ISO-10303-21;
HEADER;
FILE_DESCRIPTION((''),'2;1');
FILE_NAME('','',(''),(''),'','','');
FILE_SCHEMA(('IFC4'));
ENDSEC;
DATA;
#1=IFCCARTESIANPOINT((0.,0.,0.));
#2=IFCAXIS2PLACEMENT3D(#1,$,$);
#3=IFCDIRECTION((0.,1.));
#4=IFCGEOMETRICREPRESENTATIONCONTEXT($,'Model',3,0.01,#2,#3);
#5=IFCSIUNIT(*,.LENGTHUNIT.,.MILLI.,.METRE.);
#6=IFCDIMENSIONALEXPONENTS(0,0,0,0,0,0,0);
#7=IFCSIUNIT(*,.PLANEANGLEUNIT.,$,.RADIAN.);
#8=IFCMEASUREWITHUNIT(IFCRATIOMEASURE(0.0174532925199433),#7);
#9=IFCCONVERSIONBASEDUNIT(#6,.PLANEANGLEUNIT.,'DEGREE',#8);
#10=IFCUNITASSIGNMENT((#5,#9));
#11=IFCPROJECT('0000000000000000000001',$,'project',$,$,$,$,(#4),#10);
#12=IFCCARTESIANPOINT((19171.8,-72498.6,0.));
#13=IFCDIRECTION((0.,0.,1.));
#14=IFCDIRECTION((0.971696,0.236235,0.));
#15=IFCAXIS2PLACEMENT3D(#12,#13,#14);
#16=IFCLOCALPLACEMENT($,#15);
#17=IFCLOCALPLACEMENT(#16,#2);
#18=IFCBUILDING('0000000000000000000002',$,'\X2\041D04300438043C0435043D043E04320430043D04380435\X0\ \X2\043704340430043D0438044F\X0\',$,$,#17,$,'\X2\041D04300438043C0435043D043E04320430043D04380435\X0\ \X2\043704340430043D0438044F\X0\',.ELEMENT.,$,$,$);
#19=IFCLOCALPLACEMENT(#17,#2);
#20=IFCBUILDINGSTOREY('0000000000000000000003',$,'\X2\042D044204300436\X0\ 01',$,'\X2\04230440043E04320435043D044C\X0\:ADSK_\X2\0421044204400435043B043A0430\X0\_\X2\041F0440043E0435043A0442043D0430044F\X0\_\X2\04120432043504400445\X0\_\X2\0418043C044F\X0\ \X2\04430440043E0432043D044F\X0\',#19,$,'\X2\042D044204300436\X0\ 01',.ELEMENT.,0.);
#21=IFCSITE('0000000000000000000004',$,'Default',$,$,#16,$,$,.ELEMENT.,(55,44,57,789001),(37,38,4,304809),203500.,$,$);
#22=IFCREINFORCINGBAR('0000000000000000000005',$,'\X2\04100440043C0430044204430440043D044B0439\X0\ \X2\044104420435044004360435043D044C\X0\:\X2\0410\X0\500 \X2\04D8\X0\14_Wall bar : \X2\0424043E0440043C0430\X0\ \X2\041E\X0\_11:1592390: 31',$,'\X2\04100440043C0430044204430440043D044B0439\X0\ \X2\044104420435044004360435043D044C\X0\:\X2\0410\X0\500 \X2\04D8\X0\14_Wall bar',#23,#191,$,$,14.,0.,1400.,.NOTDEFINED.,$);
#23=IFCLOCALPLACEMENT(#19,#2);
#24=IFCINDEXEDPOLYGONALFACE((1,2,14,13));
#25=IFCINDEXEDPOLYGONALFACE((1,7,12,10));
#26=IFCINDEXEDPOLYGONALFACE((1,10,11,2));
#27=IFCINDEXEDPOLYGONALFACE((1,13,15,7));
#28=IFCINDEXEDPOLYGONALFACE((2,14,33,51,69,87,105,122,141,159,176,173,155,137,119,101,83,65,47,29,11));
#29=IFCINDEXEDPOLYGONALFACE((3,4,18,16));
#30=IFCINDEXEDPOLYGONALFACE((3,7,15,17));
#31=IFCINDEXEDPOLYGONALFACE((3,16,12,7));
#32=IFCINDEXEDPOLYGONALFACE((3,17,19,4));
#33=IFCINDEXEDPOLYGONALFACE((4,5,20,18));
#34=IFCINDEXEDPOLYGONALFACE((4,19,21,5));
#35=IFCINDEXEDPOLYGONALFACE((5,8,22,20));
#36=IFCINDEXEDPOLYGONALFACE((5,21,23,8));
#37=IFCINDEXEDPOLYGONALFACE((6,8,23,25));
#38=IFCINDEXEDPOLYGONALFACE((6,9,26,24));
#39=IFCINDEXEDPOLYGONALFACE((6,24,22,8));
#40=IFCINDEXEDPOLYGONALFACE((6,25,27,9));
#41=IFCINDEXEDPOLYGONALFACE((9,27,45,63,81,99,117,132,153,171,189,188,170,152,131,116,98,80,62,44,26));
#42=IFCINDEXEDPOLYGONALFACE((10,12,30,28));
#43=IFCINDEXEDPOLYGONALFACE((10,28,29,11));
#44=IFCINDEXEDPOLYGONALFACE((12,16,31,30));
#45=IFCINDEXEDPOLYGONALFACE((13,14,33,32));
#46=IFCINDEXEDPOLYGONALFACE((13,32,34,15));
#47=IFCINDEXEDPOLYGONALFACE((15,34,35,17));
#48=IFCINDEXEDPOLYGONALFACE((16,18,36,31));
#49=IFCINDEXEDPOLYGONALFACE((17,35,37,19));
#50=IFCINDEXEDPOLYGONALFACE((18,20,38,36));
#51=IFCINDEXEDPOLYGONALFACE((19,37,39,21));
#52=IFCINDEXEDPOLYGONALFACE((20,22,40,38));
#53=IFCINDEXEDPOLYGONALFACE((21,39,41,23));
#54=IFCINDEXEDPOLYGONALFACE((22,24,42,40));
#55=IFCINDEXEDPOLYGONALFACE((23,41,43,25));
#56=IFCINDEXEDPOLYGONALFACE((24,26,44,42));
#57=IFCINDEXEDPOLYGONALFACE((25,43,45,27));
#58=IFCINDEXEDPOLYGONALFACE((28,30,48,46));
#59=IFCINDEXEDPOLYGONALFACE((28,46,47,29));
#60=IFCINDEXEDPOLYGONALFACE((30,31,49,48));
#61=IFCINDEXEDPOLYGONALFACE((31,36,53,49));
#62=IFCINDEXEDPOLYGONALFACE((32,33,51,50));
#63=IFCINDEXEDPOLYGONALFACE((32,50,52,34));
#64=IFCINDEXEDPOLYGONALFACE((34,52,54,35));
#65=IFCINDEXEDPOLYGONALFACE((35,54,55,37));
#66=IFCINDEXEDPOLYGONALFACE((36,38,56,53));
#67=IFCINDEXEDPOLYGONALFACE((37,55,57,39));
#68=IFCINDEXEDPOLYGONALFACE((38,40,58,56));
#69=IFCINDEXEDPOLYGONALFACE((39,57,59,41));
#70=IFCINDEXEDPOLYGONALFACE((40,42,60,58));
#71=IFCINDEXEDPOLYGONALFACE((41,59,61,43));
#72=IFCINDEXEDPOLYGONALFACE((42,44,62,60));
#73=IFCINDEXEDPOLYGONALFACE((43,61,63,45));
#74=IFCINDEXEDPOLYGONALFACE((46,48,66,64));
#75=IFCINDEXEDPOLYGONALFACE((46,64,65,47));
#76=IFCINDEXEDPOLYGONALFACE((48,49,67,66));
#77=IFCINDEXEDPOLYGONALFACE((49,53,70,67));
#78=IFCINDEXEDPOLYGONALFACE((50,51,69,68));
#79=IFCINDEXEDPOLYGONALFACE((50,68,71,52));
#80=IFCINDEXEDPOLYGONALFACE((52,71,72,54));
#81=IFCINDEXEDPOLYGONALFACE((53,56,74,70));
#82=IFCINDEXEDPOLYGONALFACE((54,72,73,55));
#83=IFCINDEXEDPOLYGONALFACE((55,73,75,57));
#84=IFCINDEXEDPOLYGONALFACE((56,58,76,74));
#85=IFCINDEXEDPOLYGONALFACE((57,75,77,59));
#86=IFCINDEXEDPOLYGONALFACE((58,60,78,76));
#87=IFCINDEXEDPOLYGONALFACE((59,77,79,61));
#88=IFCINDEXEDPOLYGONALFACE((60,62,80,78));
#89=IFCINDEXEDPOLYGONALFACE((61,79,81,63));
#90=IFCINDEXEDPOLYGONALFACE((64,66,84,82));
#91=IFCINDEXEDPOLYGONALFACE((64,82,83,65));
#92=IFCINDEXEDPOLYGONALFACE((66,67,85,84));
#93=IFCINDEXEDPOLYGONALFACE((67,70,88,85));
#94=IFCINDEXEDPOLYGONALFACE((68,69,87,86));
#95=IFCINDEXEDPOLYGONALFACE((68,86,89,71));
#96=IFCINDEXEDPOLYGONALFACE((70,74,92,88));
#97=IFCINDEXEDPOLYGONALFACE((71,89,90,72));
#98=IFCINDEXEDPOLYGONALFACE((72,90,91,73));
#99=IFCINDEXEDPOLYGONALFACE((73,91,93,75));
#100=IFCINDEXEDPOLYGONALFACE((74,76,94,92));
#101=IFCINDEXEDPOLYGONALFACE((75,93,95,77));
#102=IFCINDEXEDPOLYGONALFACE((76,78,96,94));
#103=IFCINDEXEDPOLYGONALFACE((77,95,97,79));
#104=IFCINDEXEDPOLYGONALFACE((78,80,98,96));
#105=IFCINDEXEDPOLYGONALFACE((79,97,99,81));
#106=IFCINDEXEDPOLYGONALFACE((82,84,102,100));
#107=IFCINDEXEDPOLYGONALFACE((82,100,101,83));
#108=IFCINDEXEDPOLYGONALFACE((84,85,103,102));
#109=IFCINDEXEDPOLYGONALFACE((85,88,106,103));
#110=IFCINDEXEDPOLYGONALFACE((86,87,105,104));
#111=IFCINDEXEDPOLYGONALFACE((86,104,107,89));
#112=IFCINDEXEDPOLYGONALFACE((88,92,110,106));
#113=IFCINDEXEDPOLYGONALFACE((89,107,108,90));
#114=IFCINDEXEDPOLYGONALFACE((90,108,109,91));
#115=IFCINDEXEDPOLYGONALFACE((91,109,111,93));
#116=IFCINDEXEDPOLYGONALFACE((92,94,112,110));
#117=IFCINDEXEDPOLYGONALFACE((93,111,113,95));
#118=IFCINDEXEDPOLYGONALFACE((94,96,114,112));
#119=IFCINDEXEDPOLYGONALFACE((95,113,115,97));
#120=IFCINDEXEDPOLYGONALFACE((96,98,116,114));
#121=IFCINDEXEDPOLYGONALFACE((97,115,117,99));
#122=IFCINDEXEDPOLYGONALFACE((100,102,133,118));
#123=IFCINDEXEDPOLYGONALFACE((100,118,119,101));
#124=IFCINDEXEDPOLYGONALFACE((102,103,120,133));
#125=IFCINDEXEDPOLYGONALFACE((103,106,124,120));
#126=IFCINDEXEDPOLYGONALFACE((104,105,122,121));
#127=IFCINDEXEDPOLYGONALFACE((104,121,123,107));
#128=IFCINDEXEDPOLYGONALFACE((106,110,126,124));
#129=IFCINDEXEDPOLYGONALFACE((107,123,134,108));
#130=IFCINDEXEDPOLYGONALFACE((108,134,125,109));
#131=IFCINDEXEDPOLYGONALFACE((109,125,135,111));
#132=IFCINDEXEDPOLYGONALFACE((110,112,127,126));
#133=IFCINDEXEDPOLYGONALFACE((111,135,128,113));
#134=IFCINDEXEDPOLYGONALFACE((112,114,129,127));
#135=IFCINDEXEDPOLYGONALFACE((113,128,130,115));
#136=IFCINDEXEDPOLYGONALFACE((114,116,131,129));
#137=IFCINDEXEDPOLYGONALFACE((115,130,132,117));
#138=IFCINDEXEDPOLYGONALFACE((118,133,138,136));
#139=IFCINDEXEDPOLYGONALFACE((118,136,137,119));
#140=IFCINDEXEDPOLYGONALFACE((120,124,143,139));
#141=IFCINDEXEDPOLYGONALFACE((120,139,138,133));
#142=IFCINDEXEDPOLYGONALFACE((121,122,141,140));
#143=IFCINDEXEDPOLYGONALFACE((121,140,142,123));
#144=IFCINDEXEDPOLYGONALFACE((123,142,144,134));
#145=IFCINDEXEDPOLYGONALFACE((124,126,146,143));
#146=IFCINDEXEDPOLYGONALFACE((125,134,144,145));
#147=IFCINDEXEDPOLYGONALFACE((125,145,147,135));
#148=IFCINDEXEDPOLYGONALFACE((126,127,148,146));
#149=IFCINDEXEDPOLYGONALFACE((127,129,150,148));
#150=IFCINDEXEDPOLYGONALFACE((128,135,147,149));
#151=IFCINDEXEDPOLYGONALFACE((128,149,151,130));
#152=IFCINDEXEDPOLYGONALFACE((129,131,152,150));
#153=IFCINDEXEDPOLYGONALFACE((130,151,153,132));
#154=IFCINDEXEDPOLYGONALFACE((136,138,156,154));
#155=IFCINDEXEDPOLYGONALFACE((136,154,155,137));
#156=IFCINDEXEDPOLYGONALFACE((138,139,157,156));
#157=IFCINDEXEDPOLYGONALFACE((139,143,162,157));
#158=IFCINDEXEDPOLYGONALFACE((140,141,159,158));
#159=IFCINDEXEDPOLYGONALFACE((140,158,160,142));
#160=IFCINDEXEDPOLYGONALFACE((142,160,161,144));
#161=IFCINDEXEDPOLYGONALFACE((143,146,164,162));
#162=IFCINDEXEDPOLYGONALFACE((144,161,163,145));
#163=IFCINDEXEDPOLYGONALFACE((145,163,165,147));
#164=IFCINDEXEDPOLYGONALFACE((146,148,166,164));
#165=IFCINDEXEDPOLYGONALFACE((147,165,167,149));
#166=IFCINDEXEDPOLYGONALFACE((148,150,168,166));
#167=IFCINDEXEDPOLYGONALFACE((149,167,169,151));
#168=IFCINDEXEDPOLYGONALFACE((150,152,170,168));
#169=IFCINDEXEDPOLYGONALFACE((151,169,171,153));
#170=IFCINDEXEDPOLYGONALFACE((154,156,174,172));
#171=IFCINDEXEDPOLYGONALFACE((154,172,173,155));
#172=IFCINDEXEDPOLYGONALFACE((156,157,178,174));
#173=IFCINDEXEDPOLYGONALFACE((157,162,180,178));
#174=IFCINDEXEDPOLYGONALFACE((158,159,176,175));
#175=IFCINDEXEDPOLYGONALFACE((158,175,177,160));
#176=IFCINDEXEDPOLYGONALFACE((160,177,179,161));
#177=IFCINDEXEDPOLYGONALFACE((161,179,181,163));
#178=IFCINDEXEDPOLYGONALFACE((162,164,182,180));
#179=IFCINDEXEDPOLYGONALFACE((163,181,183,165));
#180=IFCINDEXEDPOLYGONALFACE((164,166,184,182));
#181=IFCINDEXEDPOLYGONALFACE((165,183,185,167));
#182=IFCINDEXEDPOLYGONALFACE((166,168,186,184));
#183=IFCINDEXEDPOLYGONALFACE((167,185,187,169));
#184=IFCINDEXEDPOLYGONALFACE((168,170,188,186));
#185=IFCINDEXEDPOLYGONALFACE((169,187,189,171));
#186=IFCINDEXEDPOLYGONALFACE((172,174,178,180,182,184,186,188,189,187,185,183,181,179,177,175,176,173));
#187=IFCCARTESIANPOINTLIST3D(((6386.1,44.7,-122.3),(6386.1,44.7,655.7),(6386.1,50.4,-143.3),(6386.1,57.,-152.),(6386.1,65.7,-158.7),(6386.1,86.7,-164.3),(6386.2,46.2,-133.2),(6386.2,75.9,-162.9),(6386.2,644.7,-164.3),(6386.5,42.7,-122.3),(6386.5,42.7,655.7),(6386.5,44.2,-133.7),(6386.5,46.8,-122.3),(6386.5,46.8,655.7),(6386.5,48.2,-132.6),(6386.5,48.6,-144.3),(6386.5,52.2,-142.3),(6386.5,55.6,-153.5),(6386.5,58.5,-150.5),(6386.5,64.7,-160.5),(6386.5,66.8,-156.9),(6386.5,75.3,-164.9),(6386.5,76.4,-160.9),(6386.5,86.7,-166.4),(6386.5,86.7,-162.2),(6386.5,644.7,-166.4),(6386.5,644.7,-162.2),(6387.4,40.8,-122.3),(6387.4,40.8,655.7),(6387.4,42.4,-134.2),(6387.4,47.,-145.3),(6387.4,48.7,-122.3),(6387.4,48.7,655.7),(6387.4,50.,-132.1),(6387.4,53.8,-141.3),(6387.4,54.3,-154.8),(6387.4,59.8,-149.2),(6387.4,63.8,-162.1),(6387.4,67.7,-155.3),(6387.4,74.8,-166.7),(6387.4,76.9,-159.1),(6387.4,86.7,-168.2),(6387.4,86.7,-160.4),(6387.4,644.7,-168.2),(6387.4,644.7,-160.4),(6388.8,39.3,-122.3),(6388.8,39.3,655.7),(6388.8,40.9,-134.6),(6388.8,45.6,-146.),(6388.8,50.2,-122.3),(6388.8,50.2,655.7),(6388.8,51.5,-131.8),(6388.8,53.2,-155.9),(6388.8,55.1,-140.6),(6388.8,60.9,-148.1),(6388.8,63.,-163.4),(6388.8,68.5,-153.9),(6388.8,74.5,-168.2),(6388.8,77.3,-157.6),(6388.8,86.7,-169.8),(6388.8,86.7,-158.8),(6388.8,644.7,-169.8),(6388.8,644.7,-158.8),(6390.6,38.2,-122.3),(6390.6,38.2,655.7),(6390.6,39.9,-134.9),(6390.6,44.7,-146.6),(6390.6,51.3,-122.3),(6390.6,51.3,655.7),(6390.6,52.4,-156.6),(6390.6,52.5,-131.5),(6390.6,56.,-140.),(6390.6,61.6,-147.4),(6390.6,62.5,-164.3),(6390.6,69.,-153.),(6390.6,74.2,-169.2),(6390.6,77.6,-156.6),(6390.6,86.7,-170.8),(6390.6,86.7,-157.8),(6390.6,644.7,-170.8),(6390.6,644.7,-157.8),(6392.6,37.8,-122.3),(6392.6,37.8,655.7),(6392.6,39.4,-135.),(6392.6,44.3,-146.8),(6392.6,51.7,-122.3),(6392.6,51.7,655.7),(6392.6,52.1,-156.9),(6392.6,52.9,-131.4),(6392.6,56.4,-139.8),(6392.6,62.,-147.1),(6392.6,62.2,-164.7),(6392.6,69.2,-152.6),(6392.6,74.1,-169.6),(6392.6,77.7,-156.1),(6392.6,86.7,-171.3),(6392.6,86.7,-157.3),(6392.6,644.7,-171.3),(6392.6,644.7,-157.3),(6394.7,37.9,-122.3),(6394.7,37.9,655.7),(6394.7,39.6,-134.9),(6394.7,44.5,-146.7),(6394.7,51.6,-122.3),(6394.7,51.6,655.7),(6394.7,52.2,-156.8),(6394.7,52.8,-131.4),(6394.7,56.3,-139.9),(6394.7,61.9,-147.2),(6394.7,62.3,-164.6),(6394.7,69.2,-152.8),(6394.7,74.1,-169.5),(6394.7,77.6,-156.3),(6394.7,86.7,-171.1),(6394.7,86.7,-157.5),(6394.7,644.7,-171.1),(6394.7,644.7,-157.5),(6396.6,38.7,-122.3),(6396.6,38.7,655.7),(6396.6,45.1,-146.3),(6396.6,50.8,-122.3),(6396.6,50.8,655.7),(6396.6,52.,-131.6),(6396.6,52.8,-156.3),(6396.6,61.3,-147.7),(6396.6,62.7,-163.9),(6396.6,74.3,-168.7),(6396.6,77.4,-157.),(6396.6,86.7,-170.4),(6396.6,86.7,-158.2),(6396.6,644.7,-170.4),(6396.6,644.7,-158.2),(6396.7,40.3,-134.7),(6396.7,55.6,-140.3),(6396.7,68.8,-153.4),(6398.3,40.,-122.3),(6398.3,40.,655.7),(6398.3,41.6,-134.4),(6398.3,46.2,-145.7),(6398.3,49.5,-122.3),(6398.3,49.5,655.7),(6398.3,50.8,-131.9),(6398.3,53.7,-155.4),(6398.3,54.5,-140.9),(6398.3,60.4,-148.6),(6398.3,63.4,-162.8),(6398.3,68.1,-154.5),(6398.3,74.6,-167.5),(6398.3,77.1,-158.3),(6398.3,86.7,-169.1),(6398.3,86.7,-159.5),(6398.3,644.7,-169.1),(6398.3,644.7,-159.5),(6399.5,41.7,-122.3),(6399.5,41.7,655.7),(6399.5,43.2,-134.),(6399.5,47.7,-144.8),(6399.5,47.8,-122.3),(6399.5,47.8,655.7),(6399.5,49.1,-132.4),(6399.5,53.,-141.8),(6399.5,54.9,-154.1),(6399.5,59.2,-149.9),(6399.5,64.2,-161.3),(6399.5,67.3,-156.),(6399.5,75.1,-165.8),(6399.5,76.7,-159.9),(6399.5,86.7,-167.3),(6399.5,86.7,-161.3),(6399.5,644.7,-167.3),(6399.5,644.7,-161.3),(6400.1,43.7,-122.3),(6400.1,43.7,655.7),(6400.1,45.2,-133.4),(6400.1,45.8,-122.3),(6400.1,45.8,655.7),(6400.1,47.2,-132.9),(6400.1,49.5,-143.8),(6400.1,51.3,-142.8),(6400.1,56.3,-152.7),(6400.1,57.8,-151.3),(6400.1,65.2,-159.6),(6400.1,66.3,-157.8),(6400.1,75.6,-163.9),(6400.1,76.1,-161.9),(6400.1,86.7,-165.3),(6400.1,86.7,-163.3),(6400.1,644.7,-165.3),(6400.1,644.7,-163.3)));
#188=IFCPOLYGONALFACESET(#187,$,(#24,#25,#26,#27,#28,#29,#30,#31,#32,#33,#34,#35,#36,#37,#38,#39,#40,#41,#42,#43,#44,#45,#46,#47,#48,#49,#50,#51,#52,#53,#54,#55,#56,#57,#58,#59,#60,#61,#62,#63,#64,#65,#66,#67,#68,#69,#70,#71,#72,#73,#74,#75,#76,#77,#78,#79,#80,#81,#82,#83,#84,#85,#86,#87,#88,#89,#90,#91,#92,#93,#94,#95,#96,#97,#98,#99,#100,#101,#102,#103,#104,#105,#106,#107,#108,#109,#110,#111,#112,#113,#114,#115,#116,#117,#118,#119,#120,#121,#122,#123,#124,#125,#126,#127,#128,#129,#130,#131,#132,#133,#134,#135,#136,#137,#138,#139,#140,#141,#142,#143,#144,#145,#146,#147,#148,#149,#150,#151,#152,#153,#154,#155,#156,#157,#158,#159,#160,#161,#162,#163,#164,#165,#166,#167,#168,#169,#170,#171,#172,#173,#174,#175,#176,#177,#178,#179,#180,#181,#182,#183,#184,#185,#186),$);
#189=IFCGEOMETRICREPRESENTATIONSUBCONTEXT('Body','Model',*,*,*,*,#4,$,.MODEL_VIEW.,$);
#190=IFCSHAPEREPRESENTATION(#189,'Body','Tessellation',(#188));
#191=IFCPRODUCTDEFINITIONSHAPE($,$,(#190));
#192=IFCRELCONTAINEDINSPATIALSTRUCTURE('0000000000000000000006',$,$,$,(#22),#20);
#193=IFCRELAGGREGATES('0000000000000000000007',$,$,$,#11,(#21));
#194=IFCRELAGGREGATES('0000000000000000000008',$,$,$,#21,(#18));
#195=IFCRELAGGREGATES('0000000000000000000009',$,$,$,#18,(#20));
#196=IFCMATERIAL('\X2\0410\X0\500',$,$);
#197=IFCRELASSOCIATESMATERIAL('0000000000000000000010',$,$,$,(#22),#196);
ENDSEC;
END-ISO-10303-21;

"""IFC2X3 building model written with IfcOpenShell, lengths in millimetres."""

from ifc_helpers import new_model, entity, si_unit, converted_unit, direction, frame, origin, place, context, subcontext, project, spatial, material, element, save


model = new_model("IFC2X3")

# Units and contexts
model_context = context("Model", 3, precision=0.01, world=origin(), true_north=direction((0.0, 1.0)))
body_context = subcontext(model_context, "Body", "Model", "MODEL_VIEW")
ifc_project = project(units=[si_unit("LENGTHUNIT", "METRE", prefix="MILLI"), converted_unit("PLANEANGLEUNIT", "DEGREE", entity("IfcRatioMeasure", 0.0174532925199433), si_unit("PLANEANGLEUNIT", "RADIAN"), dimensions=[0, 0, 0, 0, 0, 0, 0])], contexts=[model_context])

# Site, building, storey
site_placement = place(None, frame((19171.8, -72498.6, 0.0), z_axis=(0.0, 0.0, 1.0), x_axis=(0.971696, 0.236235, 0.0)))
site = spatial("IfcSite", under=ifc_project, at=site_placement, Name="Default", CompositionType="ELEMENT", RefLatitude=(55, 44, 57, 789001), RefLongitude=(37, 38, 4, 304809), RefElevation=203500.0)
building_placement = place(site_placement, origin())
building = spatial("IfcBuilding", under=site, at=building_placement, Name="Наименование здания", LongName="Наименование здания", CompositionType="ELEMENT")
storey_placement = place(building_placement, origin())
storey = spatial("IfcBuildingStorey", under=building, at=storey_placement, Name="Этаж 01", ObjectType="Уровень:ADSK_Стрелка_Проектная_Вверх_Имя уровня", LongName="Этаж 01", CompositionType="ELEMENT", Elevation=0.0)

# Reinforcing bar
ifc_material = material(Name="А500")
placement = place(storey_placement, origin())
element("IfcReinforcingBar", 1, at=placement, inside=storey, material=ifc_material, Name="Арматурный стержень:А500 Ә14_Wall bar : Форма О_11:1592390: 31", ObjectType="Арматурный стержень:А500 Ә14_Wall bar", BarLength=1400.0, BarRole="NOTDEFINED", CrossSectionArea=0.0, NominalDiameter=14.0, context=body_context, shape_type="AdvancedSweptSolid", body=[
    entity("IfcSweptDiskSolid", entity("IfcCompositeCurve", [entity("IfcCompositeCurveSegment", "CONTINUOUS", True, entity("IfcPolyline", [entity("IfcCartesianPoint", [6393.1, 44.7, 655.7]), entity("IfcCartesianPoint", [6393.1, 44.7, -122.3])])), entity("IfcCompositeCurveSegment", "CONTINUOUS", True, entity("IfcTrimmedCurve", entity("IfcCircle", entity("IfcAxis2Placement3D", entity("IfcCartesianPoint", [6393.1, 86.7, -122.3]), entity("IfcDirection", [1.0, 0.0, 0.0]), entity("IfcDirection", [0.0, 0.0, -1.0])), 42.0), [entity("IfcParameterValue", 270.0)], [entity("IfcParameterValue", 360.0)], True, "PARAMETER")), entity("IfcCompositeCurveSegment", "CONTINUOUS", True, entity("IfcPolyline", [entity("IfcCartesianPoint", [6393.1, 86.7, -164.3]), entity("IfcCartesianPoint", [6393.1, 644.7, -164.3])]))], False), 7.0, None, 0.0, 92.0),
])

save(model, "model.ifc")
